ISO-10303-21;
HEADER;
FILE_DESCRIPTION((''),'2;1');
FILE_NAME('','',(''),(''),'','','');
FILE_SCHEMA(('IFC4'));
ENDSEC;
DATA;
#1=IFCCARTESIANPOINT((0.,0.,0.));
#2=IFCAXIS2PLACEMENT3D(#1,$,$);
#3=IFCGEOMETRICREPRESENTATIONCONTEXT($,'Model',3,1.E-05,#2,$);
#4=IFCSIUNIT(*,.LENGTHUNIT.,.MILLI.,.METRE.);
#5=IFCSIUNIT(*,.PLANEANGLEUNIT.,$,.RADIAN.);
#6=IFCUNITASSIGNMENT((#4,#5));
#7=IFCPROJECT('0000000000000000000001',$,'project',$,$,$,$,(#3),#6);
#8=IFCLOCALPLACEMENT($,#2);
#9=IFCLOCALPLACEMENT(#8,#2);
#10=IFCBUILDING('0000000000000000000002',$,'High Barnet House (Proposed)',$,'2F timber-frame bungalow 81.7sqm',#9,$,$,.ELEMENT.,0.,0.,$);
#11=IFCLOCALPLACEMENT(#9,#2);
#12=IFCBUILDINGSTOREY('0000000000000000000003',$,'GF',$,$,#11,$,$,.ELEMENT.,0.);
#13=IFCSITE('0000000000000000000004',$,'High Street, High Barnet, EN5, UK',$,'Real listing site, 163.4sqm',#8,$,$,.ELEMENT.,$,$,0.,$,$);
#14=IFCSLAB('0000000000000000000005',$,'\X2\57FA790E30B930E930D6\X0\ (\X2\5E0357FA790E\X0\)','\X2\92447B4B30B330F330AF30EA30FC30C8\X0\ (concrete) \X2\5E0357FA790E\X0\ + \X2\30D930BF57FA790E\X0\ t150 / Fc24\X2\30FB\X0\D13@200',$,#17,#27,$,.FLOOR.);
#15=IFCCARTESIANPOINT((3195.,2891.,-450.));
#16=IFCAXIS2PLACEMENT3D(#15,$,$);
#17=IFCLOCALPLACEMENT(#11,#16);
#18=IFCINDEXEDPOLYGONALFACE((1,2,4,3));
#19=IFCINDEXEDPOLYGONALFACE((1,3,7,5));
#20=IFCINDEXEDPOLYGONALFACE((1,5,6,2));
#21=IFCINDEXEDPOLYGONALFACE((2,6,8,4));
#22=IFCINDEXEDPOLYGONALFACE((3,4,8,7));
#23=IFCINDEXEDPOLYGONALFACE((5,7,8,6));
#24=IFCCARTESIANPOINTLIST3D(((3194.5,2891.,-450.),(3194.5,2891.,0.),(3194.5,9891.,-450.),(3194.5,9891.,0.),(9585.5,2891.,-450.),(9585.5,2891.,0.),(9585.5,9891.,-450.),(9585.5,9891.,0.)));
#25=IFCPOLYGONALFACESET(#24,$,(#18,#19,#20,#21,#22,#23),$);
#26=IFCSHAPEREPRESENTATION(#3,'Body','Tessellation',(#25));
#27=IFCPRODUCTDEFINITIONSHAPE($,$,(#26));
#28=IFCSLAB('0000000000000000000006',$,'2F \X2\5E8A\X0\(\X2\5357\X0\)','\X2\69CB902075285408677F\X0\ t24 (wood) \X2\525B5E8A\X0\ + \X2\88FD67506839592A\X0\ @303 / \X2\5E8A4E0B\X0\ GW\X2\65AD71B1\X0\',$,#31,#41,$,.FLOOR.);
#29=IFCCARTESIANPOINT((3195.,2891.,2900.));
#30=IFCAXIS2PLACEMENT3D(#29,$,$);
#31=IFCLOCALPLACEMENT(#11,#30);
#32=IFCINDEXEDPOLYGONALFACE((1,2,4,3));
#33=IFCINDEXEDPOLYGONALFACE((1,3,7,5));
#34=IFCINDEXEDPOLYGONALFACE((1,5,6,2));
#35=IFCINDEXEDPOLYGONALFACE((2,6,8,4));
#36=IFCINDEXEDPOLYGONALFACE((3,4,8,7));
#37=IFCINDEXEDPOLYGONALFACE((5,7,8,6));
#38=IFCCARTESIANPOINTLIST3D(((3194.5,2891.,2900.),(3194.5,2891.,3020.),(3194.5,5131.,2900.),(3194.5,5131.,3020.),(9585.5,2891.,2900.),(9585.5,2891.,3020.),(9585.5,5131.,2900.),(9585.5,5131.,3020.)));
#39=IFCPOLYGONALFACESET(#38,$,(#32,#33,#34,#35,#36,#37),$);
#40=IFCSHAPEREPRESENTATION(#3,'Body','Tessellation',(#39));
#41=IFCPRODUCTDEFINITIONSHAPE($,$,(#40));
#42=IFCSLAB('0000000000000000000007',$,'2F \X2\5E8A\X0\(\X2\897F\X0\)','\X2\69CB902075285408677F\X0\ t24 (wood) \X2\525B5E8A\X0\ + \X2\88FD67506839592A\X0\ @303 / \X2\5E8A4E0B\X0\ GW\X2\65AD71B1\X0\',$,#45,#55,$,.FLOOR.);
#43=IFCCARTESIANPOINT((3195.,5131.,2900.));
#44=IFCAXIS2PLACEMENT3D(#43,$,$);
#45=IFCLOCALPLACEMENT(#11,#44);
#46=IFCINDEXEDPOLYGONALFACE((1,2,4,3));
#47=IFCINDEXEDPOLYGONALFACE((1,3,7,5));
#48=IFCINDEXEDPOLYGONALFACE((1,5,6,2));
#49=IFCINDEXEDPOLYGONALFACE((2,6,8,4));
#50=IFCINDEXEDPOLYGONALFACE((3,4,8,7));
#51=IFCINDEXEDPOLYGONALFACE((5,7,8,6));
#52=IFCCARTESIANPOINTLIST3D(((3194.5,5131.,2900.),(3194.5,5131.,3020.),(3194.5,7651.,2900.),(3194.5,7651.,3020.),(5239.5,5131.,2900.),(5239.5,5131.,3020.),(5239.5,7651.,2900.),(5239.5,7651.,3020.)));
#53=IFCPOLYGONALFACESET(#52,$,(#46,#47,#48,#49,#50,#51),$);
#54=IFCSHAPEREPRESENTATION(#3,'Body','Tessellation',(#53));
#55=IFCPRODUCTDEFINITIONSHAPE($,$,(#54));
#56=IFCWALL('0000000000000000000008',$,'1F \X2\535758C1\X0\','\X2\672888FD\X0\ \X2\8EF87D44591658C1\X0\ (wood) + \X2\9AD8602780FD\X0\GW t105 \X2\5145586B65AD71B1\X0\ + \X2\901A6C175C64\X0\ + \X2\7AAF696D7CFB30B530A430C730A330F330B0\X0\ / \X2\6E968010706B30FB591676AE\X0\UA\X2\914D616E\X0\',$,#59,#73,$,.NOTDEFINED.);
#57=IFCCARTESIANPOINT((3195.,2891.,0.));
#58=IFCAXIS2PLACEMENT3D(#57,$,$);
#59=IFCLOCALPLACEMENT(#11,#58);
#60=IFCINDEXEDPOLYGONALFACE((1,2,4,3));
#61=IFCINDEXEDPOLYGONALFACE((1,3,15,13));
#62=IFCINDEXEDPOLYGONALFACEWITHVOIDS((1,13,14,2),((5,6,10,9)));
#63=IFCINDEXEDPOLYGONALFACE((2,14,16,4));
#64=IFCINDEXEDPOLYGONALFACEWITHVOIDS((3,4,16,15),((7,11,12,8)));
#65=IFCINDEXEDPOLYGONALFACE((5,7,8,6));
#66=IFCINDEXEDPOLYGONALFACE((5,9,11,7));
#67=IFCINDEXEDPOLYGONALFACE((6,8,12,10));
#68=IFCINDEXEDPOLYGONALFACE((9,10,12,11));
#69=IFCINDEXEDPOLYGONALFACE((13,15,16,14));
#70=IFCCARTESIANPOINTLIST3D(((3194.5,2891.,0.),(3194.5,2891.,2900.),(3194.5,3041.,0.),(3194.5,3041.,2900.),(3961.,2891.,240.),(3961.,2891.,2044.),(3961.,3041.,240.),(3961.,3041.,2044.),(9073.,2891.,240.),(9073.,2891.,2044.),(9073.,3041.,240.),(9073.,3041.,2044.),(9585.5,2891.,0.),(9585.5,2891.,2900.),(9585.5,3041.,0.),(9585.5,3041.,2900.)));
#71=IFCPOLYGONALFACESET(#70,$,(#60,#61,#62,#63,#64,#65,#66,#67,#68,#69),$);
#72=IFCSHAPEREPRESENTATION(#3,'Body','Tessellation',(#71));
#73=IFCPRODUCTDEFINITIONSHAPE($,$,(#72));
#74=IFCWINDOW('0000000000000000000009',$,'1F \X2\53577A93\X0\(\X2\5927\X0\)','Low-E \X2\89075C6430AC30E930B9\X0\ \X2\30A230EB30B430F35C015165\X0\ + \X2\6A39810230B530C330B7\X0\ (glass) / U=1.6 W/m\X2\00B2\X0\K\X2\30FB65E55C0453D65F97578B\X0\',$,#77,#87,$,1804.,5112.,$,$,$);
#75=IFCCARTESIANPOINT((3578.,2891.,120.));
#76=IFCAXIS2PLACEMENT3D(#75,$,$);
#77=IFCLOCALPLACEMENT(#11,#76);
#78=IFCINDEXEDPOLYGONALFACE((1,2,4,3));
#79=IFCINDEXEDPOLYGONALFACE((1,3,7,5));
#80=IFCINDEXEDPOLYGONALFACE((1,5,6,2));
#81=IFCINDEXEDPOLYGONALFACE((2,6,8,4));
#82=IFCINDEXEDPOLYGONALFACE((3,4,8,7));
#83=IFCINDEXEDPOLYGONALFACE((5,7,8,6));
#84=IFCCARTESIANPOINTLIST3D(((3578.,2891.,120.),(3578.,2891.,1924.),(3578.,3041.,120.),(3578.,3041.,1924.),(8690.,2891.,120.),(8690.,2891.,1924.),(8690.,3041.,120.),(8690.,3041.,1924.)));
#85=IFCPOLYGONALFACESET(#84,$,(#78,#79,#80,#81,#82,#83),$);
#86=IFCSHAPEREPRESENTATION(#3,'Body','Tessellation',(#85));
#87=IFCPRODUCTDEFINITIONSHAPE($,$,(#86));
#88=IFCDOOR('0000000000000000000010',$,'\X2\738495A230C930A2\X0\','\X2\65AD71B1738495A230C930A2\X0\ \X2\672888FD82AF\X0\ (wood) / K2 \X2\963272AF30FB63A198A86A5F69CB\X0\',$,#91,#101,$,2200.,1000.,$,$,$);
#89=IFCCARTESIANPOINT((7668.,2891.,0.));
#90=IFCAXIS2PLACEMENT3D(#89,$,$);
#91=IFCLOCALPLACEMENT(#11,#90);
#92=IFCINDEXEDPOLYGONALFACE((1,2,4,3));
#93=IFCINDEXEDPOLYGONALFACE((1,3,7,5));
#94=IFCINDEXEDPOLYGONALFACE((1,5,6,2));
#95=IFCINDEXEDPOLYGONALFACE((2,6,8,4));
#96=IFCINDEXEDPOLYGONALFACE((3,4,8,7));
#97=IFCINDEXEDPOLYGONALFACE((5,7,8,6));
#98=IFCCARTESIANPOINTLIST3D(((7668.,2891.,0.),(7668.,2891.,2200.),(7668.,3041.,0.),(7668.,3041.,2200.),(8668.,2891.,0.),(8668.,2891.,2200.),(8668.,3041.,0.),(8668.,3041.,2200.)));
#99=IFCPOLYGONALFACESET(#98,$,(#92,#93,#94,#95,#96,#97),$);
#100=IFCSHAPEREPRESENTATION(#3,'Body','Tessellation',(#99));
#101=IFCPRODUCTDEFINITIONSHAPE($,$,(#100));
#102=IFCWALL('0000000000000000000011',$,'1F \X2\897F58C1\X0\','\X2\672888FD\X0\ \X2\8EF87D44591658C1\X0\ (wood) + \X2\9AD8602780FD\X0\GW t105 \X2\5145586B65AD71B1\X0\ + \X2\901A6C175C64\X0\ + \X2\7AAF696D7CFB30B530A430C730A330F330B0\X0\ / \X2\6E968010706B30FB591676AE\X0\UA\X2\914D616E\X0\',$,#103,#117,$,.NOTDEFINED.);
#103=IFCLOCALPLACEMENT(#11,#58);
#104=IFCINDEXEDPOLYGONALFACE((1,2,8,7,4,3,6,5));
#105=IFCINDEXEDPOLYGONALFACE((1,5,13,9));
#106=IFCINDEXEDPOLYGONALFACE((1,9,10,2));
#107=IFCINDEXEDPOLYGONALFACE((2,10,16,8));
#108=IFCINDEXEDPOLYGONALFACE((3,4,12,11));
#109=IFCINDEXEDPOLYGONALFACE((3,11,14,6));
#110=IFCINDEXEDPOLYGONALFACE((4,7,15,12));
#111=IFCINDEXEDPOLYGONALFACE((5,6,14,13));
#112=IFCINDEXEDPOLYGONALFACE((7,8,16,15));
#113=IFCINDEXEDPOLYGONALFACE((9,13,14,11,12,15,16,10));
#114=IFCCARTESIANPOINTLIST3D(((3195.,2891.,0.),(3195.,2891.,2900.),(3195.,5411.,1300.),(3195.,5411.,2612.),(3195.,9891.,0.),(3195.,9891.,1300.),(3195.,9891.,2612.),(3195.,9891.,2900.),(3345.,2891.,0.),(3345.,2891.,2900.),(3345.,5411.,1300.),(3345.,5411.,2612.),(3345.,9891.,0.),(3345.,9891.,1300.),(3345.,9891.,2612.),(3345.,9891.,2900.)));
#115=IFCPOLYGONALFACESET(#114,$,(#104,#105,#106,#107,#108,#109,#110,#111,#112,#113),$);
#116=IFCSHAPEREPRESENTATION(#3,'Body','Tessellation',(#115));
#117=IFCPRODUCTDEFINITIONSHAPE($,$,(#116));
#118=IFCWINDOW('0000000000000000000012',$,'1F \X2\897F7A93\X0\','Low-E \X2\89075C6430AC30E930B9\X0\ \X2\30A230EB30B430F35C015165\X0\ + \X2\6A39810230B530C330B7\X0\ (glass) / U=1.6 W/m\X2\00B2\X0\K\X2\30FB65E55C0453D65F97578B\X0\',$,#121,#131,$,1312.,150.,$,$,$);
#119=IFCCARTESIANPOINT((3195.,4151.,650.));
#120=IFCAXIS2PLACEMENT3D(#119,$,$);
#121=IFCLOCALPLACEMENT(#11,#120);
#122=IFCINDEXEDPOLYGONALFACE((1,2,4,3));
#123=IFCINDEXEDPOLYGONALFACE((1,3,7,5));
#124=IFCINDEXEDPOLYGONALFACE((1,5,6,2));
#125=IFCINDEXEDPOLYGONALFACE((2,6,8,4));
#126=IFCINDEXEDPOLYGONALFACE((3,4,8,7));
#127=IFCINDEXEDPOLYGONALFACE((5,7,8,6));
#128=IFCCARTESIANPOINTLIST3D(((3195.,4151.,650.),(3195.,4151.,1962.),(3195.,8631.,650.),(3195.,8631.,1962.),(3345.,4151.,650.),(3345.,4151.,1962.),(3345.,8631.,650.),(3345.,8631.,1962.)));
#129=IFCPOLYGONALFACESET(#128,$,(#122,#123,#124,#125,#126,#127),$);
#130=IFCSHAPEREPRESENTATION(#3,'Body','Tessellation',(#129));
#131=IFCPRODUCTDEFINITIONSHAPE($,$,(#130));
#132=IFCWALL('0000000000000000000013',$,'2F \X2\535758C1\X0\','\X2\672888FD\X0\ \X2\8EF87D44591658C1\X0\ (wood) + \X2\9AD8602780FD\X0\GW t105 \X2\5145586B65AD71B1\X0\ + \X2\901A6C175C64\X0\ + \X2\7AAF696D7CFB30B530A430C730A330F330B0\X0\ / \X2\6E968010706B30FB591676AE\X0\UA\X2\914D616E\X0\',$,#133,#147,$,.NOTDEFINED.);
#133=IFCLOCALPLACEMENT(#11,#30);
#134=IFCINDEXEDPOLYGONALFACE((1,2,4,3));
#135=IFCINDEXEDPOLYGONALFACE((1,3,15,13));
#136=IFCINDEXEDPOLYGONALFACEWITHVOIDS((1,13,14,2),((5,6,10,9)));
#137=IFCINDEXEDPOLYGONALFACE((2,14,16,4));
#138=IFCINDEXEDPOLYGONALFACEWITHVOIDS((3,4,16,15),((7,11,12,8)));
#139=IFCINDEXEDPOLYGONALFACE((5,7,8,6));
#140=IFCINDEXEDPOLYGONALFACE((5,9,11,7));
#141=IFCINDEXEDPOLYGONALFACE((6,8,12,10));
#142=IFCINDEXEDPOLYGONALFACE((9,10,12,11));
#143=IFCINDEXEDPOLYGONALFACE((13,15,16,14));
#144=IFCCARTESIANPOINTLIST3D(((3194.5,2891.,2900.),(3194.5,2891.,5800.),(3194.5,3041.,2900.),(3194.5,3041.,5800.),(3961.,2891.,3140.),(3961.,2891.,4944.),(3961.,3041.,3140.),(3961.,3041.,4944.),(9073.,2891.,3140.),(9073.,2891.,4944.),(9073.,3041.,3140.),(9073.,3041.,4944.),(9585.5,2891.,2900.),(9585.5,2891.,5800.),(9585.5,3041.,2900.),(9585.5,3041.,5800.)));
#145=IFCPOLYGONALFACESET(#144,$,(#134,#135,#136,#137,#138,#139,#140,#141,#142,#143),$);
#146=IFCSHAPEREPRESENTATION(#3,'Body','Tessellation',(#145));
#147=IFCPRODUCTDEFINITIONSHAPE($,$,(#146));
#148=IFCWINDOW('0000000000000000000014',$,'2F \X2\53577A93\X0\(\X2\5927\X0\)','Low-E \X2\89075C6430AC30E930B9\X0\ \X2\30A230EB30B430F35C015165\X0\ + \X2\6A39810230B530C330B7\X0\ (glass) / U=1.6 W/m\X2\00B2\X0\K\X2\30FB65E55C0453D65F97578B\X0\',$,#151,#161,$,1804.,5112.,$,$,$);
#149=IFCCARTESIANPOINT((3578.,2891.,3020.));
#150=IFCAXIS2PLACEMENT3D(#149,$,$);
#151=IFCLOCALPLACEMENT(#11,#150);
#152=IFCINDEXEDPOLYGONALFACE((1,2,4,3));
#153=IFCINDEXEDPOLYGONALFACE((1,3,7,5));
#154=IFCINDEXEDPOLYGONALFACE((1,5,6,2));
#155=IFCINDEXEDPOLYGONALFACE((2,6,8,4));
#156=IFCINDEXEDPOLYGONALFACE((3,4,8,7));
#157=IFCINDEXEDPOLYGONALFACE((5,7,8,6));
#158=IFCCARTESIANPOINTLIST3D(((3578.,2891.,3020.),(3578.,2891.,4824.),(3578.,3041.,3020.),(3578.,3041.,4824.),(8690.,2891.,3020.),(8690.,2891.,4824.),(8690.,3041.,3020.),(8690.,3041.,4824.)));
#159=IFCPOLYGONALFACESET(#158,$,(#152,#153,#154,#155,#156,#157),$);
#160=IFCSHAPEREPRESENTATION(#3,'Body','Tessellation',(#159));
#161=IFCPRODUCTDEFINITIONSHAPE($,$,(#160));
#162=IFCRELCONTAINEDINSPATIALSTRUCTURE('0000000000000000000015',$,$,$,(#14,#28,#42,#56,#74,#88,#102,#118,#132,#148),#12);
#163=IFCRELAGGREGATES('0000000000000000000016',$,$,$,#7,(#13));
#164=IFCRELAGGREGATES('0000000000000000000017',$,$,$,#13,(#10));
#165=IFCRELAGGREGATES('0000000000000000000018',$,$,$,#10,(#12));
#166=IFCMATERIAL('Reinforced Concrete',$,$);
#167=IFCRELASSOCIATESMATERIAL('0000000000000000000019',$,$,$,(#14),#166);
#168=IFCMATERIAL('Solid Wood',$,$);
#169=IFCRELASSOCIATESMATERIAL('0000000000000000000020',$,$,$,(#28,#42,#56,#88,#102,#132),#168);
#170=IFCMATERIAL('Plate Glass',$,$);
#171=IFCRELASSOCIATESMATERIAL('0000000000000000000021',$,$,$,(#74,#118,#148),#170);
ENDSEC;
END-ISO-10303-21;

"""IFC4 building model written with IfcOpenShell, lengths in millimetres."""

from ifc_helpers import new_model, si_unit, frame, frame_2d, origin, place, context, project, spatial, rectangle, extrude, material, element, fill, save


model = new_model("IFC4")

# Units and contexts
model_context = context("Model", 3, precision=1e-05, world=origin())
ifc_project = project(units=[si_unit("LENGTHUNIT", "METRE", prefix="MILLI"), si_unit("PLANEANGLEUNIT", "RADIAN")], contexts=[model_context])

# Site, building, storey
site_placement = place(None, origin())
site = spatial("IfcSite", under=ifc_project, at=site_placement, Name="High Street, High Barnet, EN5, UK", ObjectType="Real listing site, 163.4sqm", CompositionType="ELEMENT", RefElevation=0.0)
building_placement = place(site_placement, origin())
building = spatial("IfcBuilding", under=site, at=building_placement, Name="High Barnet House (Proposed)", ObjectType="2F timber-frame bungalow 81.7sqm", CompositionType="ELEMENT", ElevationOfRefHeight=0.0, ElevationOfTerrain=0.0)
storey_placement = place(building_placement, origin())
storey = spatial("IfcBuildingStorey", under=building, at=storey_placement, Name="GF", CompositionType="ELEMENT", Elevation=0.0)

# Slabs
ifc_material_1 = material(Name="Reinforced Concrete")
slab_1_placement = place(storey_placement, frame((3195.0, 2891.0, -450.0)))
element("IfcSlab", 1, at=slab_1_placement, inside=storey, material=ifc_material_1, Name="基礎スラブ (布基礎)", Description="鉄筋コンクリート (concrete) 布基礎 + ベタ基礎 t150 / Fc24・D13@200", PredefinedType="FLOOR", context=model_context, shape_type="SweptSolid", body=[
    extrude(rectangle(XDim=6391.0, YDim=7000.0, at=frame_2d((3195.0, 3500.0))), frame((3195.0, 2891.0, -450.0)), (0.0, 0.0, 1.0), 450.0),
])
ifc_material_2 = material(Name="Solid Wood")
slab_2_placement = place(storey_placement, frame((3195.0, 2891.0, 2900.0)))
element("IfcSlab", 2, at=slab_2_placement, inside=storey, material=ifc_material_2, Name="2F 床(南)", Description="構造用合板 t24 (wood) 剛床 + 製材根太 @303 / 床下 GW断熱", PredefinedType="FLOOR", context=model_context, shape_type="SweptSolid", body=[
    extrude(rectangle(XDim=6391.0, YDim=2240.0, at=frame_2d((3195.0, 1120.0))), frame((3195.0, 2891.0, 2900.0)), (0.0, 0.0, 1.0), 120.0),
])
slab_3_placement = place(storey_placement, frame((3195.0, 5131.0, 2900.0)))
element("IfcSlab", 3, at=slab_3_placement, inside=storey, material=ifc_material_2, Name="2F 床(西)", Description="構造用合板 t24 (wood) 剛床 + 製材根太 @303 / 床下 GW断熱", PredefinedType="FLOOR", context=model_context, shape_type="SweptSolid", body=[
    extrude(rectangle(XDim=2045.0, YDim=2520.0, at=frame_2d((1022.0, 1260.0))), frame((3195.0, 5131.0, 2900.0)), (0.0, 0.0, 1.0), 120.0),
])

# Wall, openings, window, door
wall_1_placement = place(storey_placement, frame((3195.0, 2891.0, 0.0)))
wall_1 = element("IfcWall", 4, at=wall_1_placement, inside=storey, material=ifc_material_2, Name="1F 南壁", Description="木製 軸組外壁 (wood) + 高性能GW t105 充填断熱 + 通気層 + 窯業系サイディング / 準耐火・外皮UA配慮", PredefinedType="NOTDEFINED", context=model_context, shape_type="SweptSolid", body=[
    extrude(rectangle(XDim=6391.0, YDim=150.0, at=frame_2d((3195.0, 75.0))), frame((3195.0, 2891.0, 0.0)), (0.0, 0.0, 1.0), 2900.0),
])
opening_1_placement = place(storey_placement, frame((3578.0, 2891.0, 120.0)))
opening_1 = element("IfcOpeningElement", 5, at=opening_1_placement, cuts=wall_1, PredefinedType="NOTDEFINED", context=model_context, shape_type="SweptSolid", body=[
    extrude(rectangle(XDim=5112.0, YDim=150.0, at=frame_2d((2556.0, 75.0))), frame((3578.0, 2891.0, 120.0)), (0.0, 0.0, 1.0), 1804.0),
])
opening_2_placement = place(storey_placement, frame((7668.0, 2891.0, 0.0)))
opening_2 = element("IfcOpeningElement", 6, at=opening_2_placement, cuts=wall_1, PredefinedType="NOTDEFINED", context=model_context, shape_type="SweptSolid", body=[
    extrude(rectangle(XDim=1000.0, YDim=150.0, at=frame_2d((500.0, 75.0))), frame((7668.0, 2891.0, 0.0)), (0.0, 0.0, 1.0), 2200.0),
])
ifc_material_3 = material(Name="Plate Glass")
window_1_placement = place(storey_placement, frame((3578.0, 2891.0, 120.0)))
window_1 = element("IfcWindow", 7, at=window_1_placement, inside=storey, material=ifc_material_3, Name="1F 南窓(大)", Description="Low-E 複層ガラス アルゴン封入 + 樹脂サッシ (glass) / U=1.6 W/m²K・日射取得型", OverallHeight=1804.0, OverallWidth=5112.0, context=model_context, shape_type="SweptSolid", body=[
    extrude(rectangle(XDim=5112.0, YDim=150.0, at=frame_2d((2556.0, 75.0))), frame((3578.0, 2891.0, 120.0)), (0.0, 0.0, 1.0), 1804.0),
])
fill(opening_1, window_1)
door_placement = place(storey_placement, frame((7668.0, 2891.0, 0.0)))
door = element("IfcDoor", 8, at=door_placement, inside=storey, material=ifc_material_2, Name="玄関ドア", Description="断熱玄関ドア 木製芯 (wood) / K2 防犯・採風機構", OverallHeight=2200.0, OverallWidth=1000.0, context=model_context, shape_type="SweptSolid", body=[
    extrude(rectangle(XDim=1000.0, YDim=150.0, at=frame_2d((500.0, 75.0))), frame((7668.0, 2891.0, 0.0)), (0.0, 0.0, 1.0), 2200.0),
])
fill(opening_2, door)

# Walls, openings, windows
wall_2_placement = place(storey_placement, frame((3195.0, 2891.0, 0.0)))
wall_2 = element("IfcWall", 9, at=wall_2_placement, inside=storey, material=ifc_material_2, Name="1F 西壁", Description="木製 軸組外壁 (wood) + 高性能GW t105 充填断熱 + 通気層 + 窯業系サイディング / 準耐火・外皮UA配慮", PredefinedType="NOTDEFINED", context=model_context, shape_type="SweptSolid", body=[
    extrude(rectangle(XDim=150.0, YDim=7000.0, at=frame_2d((75.0, 3500.0))), frame((3195.0, 2891.0, 0.0)), (0.0, 0.0, 1.0), 2900.0),
])
opening_3_placement = place(storey_placement, frame((3195.0, 4151.0, 650.0)))
opening_3 = element("IfcOpeningElement", 10, at=opening_3_placement, cuts=wall_2, PredefinedType="NOTDEFINED", context=model_context, shape_type="SweptSolid", body=[
    extrude(rectangle(XDim=150.0, YDim=4480.0, at=frame_2d((75.0, 2240.0))), frame((3195.0, 4151.0, 650.0)), (0.0, 0.0, 1.0), 1312.0),
])
window_2_placement = place(storey_placement, frame((3195.0, 4151.0, 650.0)))
window_2 = element("IfcWindow", 11, at=window_2_placement, inside=storey, material=ifc_material_3, Name="1F 西窓", Description="Low-E 複層ガラス アルゴン封入 + 樹脂サッシ (glass) / U=1.6 W/m²K・日射取得型", OverallHeight=1312.0, OverallWidth=150.0, context=model_context, shape_type="SweptSolid", body=[
    extrude(rectangle(XDim=150.0, YDim=4480.0, at=frame_2d((75.0, 2240.0))), frame((3195.0, 4151.0, 650.0)), (0.0, 0.0, 1.0), 1312.0),
])
fill(opening_3, window_2)
wall_3_placement = place(storey_placement, frame((3195.0, 2891.0, 2900.0)))
wall_3 = element("IfcWall", 12, at=wall_3_placement, inside=storey, material=ifc_material_2, Name="2F 南壁", Description="木製 軸組外壁 (wood) + 高性能GW t105 充填断熱 + 通気層 + 窯業系サイディング / 準耐火・外皮UA配慮", PredefinedType="NOTDEFINED", context=model_context, shape_type="SweptSolid", body=[
    extrude(rectangle(XDim=6391.0, YDim=150.0, at=frame_2d((3195.0, 75.0))), frame((3195.0, 2891.0, 2900.0)), (0.0, 0.0, 1.0), 2900.0),
])
opening_4_placement = place(storey_placement, frame((3578.0, 2891.0, 3020.0)))
opening_4 = element("IfcOpeningElement", 13, at=opening_4_placement, cuts=wall_3, PredefinedType="NOTDEFINED", context=model_context, shape_type="SweptSolid", body=[
    extrude(rectangle(XDim=5112.0, YDim=150.0, at=frame_2d((2556.0, 75.0))), frame((3578.0, 2891.0, 3020.0)), (0.0, 0.0, 1.0), 1804.0),
])
window_3_placement = place(storey_placement, frame((3578.0, 2891.0, 3020.0)))
window_3 = element("IfcWindow", 14, at=window_3_placement, inside=storey, material=ifc_material_3, Name="2F 南窓(大)", Description="Low-E 複層ガラス アルゴン封入 + 樹脂サッシ (glass) / U=1.6 W/m²K・日射取得型", OverallHeight=1804.0, OverallWidth=5112.0, context=model_context, shape_type="SweptSolid", body=[
    extrude(rectangle(XDim=5112.0, YDim=150.0, at=frame_2d((2556.0, 75.0))), frame((3578.0, 2891.0, 3020.0)), (0.0, 0.0, 1.0), 1804.0),
])
fill(opening_4, window_3)

save(model, "model.ifc")
